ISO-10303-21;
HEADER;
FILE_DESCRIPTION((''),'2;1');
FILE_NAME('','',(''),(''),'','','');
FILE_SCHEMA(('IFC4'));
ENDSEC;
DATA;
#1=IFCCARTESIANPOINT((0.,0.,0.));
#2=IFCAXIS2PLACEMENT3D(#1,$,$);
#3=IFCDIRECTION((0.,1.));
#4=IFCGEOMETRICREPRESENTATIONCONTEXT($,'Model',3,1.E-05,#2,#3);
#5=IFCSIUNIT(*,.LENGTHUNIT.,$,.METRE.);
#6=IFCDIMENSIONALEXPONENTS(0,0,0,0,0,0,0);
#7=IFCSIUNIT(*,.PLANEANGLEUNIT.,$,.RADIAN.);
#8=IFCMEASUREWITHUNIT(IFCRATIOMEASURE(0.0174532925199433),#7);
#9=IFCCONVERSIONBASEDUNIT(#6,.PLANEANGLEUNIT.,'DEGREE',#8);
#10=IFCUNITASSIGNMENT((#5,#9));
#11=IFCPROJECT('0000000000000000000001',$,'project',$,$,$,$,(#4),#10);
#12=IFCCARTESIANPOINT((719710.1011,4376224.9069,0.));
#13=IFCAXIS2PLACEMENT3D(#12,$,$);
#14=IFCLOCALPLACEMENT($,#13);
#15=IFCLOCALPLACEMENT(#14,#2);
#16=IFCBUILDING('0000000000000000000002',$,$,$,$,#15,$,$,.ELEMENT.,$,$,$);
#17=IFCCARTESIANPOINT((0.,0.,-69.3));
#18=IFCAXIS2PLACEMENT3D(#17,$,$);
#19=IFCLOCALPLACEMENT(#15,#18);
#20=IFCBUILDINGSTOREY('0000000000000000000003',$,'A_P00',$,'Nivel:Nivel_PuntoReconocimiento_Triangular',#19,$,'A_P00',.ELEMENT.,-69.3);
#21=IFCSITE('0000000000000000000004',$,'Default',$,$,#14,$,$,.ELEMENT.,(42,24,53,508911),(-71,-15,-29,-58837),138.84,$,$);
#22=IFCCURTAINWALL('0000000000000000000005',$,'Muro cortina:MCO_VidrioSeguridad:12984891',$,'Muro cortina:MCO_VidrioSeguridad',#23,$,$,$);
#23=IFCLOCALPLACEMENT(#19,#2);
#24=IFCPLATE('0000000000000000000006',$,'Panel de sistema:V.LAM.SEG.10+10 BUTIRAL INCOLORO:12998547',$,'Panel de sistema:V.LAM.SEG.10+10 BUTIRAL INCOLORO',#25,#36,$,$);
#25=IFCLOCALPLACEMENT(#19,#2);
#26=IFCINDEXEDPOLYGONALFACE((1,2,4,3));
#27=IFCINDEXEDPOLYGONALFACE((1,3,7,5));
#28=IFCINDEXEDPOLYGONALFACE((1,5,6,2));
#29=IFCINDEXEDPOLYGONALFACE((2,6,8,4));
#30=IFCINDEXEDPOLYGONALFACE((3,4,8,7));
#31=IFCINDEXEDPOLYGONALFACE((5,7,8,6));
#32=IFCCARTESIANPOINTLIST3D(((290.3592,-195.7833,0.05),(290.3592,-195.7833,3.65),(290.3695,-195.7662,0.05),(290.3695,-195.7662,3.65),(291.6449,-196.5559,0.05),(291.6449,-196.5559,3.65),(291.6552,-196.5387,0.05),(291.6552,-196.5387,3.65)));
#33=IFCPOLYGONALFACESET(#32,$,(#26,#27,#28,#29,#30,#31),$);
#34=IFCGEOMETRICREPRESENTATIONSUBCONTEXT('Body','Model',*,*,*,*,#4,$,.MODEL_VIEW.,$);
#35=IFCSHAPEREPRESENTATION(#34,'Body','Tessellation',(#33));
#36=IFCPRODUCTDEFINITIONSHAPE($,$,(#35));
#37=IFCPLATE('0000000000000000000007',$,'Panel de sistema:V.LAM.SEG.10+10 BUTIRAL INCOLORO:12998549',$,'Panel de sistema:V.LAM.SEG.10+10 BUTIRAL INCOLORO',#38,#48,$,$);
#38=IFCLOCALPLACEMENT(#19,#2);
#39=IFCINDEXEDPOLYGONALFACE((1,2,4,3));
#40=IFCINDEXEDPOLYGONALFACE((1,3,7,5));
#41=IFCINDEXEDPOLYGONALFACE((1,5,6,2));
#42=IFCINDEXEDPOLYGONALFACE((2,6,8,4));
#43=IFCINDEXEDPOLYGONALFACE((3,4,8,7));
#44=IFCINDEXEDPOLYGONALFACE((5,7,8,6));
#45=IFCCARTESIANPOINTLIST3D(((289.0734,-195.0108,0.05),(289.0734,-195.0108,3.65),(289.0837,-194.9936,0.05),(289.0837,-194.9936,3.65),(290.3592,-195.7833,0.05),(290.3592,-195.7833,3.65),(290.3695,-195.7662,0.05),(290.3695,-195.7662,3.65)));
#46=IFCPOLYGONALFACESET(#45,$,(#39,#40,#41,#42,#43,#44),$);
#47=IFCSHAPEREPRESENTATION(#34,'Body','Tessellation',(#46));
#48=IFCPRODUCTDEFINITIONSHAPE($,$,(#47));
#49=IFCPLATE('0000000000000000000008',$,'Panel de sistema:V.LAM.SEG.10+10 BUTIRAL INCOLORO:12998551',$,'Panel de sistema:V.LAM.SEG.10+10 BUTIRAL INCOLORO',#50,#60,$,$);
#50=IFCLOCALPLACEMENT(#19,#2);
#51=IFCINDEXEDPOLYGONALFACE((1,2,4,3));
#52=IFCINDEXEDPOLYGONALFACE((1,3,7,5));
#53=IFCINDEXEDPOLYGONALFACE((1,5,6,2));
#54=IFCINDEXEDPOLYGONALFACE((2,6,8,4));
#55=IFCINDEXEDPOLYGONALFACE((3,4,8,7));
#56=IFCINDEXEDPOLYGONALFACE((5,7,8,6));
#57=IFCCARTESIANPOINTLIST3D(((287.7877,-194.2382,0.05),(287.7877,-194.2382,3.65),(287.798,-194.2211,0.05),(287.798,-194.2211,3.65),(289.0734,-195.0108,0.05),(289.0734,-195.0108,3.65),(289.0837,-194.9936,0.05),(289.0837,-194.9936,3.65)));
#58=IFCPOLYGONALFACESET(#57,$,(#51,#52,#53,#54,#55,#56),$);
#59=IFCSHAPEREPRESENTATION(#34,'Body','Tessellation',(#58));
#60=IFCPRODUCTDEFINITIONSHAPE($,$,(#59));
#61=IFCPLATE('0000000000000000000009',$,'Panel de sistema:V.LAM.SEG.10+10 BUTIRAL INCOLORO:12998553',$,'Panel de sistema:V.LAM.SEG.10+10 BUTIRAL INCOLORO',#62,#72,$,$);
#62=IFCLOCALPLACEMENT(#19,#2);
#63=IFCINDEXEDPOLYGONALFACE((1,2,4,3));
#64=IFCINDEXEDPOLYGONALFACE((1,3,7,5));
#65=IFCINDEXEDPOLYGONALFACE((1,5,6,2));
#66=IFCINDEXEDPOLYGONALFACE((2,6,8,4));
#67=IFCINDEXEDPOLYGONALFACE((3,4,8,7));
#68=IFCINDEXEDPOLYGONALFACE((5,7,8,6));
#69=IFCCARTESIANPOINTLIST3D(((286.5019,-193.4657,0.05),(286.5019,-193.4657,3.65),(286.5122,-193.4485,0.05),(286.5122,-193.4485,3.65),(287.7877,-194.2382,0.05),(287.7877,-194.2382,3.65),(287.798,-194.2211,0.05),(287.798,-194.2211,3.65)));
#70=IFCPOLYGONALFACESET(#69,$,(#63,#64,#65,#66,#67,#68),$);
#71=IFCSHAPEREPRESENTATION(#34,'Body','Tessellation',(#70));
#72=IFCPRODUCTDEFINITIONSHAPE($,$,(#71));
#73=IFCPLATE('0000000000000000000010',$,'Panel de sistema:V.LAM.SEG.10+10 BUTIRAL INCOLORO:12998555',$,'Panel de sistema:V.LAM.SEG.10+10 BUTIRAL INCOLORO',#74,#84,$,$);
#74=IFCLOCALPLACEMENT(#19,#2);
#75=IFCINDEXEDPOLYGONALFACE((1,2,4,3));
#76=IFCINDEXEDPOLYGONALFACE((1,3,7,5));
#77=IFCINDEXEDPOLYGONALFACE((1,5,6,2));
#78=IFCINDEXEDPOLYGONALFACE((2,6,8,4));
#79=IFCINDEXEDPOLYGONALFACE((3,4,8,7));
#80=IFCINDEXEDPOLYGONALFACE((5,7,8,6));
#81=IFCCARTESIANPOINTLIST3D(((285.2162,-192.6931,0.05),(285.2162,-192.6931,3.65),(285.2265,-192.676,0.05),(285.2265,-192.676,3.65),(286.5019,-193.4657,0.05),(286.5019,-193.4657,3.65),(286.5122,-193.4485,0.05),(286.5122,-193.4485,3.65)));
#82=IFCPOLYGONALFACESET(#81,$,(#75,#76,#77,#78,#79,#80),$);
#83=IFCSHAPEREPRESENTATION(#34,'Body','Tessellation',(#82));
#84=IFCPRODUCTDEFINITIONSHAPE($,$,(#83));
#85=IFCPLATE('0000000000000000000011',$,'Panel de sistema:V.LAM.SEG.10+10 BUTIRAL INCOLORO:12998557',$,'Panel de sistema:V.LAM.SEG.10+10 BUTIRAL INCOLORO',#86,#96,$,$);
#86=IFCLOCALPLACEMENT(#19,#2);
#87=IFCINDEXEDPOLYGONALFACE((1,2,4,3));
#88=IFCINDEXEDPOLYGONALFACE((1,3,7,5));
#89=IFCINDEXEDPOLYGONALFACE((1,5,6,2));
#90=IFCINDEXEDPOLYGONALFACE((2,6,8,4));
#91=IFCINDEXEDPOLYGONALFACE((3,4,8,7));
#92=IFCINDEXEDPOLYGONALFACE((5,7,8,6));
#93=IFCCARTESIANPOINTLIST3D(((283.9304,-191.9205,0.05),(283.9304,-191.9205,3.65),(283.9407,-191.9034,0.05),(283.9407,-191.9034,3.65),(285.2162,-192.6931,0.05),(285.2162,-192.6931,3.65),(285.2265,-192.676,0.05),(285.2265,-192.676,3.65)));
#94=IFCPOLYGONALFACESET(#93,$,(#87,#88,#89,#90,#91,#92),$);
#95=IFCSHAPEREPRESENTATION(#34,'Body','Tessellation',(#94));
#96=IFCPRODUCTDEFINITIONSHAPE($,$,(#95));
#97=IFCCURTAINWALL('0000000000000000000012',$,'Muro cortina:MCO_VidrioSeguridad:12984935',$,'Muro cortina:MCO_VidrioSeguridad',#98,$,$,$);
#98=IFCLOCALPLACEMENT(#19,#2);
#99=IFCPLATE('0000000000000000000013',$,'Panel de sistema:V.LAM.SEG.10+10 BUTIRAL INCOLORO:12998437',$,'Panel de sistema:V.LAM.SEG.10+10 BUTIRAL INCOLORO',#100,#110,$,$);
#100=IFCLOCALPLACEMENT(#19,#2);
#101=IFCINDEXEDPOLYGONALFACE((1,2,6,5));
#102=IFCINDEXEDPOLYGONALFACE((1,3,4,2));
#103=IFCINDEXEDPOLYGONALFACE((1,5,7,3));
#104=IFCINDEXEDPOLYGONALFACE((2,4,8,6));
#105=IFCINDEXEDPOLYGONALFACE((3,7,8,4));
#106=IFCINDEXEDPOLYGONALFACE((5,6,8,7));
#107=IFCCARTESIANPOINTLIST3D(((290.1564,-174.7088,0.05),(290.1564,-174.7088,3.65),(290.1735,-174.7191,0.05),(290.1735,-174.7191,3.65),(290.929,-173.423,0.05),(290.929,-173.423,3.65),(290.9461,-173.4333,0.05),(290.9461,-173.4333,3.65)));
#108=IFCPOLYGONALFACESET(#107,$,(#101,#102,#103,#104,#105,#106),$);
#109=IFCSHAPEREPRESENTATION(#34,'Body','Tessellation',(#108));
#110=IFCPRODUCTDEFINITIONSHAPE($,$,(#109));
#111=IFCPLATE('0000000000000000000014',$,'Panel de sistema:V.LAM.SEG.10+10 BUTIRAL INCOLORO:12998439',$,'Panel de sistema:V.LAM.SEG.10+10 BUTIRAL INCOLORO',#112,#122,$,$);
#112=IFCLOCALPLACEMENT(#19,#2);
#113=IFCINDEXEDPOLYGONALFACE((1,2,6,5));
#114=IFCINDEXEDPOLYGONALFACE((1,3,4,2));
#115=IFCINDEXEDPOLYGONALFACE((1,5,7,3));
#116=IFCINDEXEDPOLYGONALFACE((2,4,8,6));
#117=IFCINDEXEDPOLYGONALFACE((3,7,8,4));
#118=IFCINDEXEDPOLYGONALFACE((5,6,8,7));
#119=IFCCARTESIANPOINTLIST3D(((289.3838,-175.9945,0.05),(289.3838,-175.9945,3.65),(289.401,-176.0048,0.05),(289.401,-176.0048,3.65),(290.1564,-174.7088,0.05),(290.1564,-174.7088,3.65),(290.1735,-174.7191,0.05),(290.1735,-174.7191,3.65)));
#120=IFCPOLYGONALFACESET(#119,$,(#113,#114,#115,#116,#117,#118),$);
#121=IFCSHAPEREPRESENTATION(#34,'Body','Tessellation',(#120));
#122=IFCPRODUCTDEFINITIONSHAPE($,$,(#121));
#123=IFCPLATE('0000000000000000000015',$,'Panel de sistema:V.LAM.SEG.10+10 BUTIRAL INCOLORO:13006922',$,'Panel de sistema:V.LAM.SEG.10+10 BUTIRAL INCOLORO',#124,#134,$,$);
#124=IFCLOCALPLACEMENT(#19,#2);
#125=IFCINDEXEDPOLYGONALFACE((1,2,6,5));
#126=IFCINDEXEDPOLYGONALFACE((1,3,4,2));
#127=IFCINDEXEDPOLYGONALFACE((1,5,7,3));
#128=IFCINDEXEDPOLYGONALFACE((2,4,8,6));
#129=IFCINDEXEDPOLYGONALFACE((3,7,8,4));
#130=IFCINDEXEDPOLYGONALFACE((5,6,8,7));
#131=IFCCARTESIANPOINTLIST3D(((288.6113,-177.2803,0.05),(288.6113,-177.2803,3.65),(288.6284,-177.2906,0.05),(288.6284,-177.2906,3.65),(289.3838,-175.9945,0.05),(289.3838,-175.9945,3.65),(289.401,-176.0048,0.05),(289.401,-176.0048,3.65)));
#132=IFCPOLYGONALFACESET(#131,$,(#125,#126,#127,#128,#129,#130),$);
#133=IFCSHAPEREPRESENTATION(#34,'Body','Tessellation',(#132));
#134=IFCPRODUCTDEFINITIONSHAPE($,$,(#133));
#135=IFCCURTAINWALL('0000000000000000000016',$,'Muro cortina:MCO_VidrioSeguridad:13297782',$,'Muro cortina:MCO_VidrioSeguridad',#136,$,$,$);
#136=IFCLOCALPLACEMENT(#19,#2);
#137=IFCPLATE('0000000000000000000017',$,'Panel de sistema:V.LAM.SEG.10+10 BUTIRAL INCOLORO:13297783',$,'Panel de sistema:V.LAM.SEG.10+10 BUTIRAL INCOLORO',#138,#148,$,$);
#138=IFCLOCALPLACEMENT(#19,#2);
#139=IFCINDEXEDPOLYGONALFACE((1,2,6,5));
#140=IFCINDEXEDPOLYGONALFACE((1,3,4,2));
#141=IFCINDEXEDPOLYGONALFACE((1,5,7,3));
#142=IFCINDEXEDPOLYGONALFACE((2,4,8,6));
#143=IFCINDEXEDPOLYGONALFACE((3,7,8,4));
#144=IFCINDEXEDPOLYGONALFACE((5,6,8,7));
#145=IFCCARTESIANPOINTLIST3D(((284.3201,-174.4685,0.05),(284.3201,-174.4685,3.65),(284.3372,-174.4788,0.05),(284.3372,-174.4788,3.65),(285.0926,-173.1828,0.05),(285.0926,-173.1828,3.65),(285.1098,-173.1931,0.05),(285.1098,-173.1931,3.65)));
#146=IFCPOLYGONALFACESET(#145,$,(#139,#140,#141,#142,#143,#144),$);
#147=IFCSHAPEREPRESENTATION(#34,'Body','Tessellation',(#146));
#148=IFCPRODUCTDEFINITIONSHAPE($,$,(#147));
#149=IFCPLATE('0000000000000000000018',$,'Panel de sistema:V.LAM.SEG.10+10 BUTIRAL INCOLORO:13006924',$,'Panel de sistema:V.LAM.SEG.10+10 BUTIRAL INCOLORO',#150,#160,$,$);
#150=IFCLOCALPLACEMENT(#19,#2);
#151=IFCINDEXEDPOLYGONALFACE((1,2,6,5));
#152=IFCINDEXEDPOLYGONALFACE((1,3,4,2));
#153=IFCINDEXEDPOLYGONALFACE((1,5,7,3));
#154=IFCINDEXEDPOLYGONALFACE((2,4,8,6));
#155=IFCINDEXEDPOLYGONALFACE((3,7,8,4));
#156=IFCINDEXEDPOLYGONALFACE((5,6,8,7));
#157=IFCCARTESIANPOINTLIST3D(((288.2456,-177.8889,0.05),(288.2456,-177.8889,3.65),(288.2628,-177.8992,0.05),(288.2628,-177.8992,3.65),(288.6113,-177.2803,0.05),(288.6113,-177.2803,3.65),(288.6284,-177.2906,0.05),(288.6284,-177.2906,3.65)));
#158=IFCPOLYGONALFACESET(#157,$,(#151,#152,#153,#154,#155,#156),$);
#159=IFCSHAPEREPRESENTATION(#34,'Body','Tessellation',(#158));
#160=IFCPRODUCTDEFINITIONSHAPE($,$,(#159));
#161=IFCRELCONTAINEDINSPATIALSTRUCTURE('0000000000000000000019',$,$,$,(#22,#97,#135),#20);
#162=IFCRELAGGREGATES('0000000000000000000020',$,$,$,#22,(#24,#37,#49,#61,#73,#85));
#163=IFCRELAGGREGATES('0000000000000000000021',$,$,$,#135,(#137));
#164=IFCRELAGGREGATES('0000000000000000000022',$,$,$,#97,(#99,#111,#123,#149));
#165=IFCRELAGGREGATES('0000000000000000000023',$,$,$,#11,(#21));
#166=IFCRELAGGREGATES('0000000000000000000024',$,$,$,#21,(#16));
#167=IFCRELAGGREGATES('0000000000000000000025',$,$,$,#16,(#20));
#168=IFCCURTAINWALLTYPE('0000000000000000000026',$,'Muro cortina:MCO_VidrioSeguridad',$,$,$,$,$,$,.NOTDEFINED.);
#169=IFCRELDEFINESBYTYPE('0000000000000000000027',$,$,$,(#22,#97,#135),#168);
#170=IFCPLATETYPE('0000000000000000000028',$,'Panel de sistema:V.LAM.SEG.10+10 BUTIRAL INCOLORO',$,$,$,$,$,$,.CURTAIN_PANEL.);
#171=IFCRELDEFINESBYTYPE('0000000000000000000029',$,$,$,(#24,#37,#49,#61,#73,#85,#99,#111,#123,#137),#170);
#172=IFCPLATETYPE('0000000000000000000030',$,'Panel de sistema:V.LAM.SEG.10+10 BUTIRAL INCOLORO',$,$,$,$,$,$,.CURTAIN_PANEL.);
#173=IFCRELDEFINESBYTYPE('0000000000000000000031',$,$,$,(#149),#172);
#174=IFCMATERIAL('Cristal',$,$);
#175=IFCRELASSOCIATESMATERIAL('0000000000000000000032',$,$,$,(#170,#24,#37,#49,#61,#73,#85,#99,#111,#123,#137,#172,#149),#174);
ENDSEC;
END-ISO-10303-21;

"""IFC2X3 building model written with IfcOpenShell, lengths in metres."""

from ifc_helpers import new_model, entity, si_unit, converted_unit, direction, frame, origin, origin_2d_with_axis, place, context, subcontext, project, spatial, rectangle, extrude, source, transform, mapped, material, type_object, type_shapes, element, aggregate, save


model = new_model("IFC2X3")

# Units and contexts
model_context = context("Model", 3, precision=1e-05, world=origin(), true_north=direction((0.0, 1.0)))
body_context = subcontext(model_context, "Body", "Model", "MODEL_VIEW")
ifc_project = project(units=[si_unit("LENGTHUNIT", "METRE"), converted_unit("PLANEANGLEUNIT", "DEGREE", entity("IfcRatioMeasure", 0.0174532925199433), si_unit("PLANEANGLEUNIT", "RADIAN"), dimensions=[0, 0, 0, 0, 0, 0, 0])], contexts=[model_context])

# Site, building, storey
site_placement = place(None, frame((719710.1011, 4376224.9069, 0.0)))
site = spatial("IfcSite", under=ifc_project, at=site_placement, Name="Default", CompositionType="ELEMENT", RefLatitude=(42, 24, 53, 508911), RefLongitude=(-71, -15, -29, -58837), RefElevation=138.84)
building_placement = place(site_placement, origin())
building = spatial("IfcBuilding", under=site, at=building_placement, CompositionType="ELEMENT")
storey_placement = place(building_placement, frame((0.0, 0.0, -69.3)))
storey = spatial("IfcBuildingStorey", under=building, at=storey_placement, Name="A_P00", ObjectType="Nivel:Nivel_PuntoReconocimiento_Triangular", LongName="A_P00", CompositionType="ELEMENT", Elevation=-69.3)

# Curtain walls, plates
curtain_wall_type = type_object("IfcCurtainWallType", Name="Muro cortina:MCO_VidrioSeguridad", PredefinedType="NOTDEFINED")
curtain_wall_1_placement = place(storey_placement, frame((0.0, 0.0, 69.3)))
curtain_wall_1 = element("IfcCurtainWall", 1, at=curtain_wall_1_placement, inside=storey, type_object=curtain_wall_type, Name="Muro cortina:MCO_VidrioSeguridad:12984891", ObjectType="Muro cortina:MCO_VidrioSeguridad")
ifc_material_1 = material(Name="Cristal")
plate_type_1 = type_object("IfcPlateType", Name="Panel de sistema:V.LAM.SEG.10+10 BUTIRAL INCOLORO", PredefinedType="CURTAIN_PANEL", material=ifc_material_1)
shared_shape_1 = source(origin(), body_context, "Body", "SweptSolid", [
    extrude(rectangle(XDim=0.02, YDim=1.5, at=origin_2d_with_axis()), frame((0.0, 0.0, 0.0), z_axis=(0.0, 0.0, 1.0), x_axis=(0.0, 1.0, 0.0)), (0.0, 0.0, 1.0), 3.6),
])
type_shapes(plate_type_1, [shared_shape_1])
plate_1_placement = place(curtain_wall_1_placement, frame((291.0072, -196.161, -69.25), z_axis=(0.0, 0.0, 1.0), x_axis=(-0.857167, 0.515038, 0.0)))
plate_1 = element("IfcPlate", 2, at=plate_1_placement, type_object=plate_type_1, material=ifc_material_1, Name="Panel de sistema:V.LAM.SEG.10+10 BUTIRAL INCOLORO:12998547", ObjectType="Panel de sistema:V.LAM.SEG.10+10 BUTIRAL INCOLORO", context=body_context, shape_type="MappedRepresentation", body=[
    mapped(shared_shape_1, transform((0.0, 0.0, 0.0), scale=1.0)),
])
plate_2_placement = place(curtain_wall_1_placement, frame((289.7214, -195.3885, -69.25), z_axis=(0.0, 0.0, 1.0), x_axis=(-0.857167, 0.515038, 0.0)))
plate_2 = element("IfcPlate", 3, at=plate_2_placement, type_object=plate_type_1, material=ifc_material_1, Name="Panel de sistema:V.LAM.SEG.10+10 BUTIRAL INCOLORO:12998549", ObjectType="Panel de sistema:V.LAM.SEG.10+10 BUTIRAL INCOLORO", context=body_context, shape_type="MappedRepresentation", body=[
    mapped(shared_shape_1, transform((0.0, 0.0, 0.0), scale=1.0)),
])
plate_3_placement = place(curtain_wall_1_placement, frame((288.4357, -194.6159, -69.25), z_axis=(0.0, 0.0, 1.0), x_axis=(-0.857167, 0.515038, 0.0)))
plate_3 = element("IfcPlate", 4, at=plate_3_placement, type_object=plate_type_1, material=ifc_material_1, Name="Panel de sistema:V.LAM.SEG.10+10 BUTIRAL INCOLORO:12998551", ObjectType="Panel de sistema:V.LAM.SEG.10+10 BUTIRAL INCOLORO", context=body_context, shape_type="MappedRepresentation", body=[
    mapped(shared_shape_1, transform((0.0, 0.0, 0.0), scale=1.0)),
])
plate_4_placement = place(curtain_wall_1_placement, frame((287.1499, -193.8434, -69.25), z_axis=(0.0, 0.0, 1.0), x_axis=(-0.857167, 0.515038, 0.0)))
plate_4 = element("IfcPlate", 5, at=plate_4_placement, type_object=plate_type_1, material=ifc_material_1, Name="Panel de sistema:V.LAM.SEG.10+10 BUTIRAL INCOLORO:12998553", ObjectType="Panel de sistema:V.LAM.SEG.10+10 BUTIRAL INCOLORO", context=body_context, shape_type="MappedRepresentation", body=[
    mapped(shared_shape_1, transform((0.0, 0.0, 0.0), scale=1.0)),
])
plate_5_placement = place(curtain_wall_1_placement, frame((285.8642, -193.0708, -69.25), z_axis=(0.0, 0.0, 1.0), x_axis=(-0.857167, 0.515038, 0.0)))
plate_5 = element("IfcPlate", 6, at=plate_5_placement, type_object=plate_type_1, material=ifc_material_1, Name="Panel de sistema:V.LAM.SEG.10+10 BUTIRAL INCOLORO:12998555", ObjectType="Panel de sistema:V.LAM.SEG.10+10 BUTIRAL INCOLORO", context=body_context, shape_type="MappedRepresentation", body=[
    mapped(shared_shape_1, transform((0.0, 0.0, 0.0), scale=1.0)),
])
plate_6_placement = place(curtain_wall_1_placement, frame((284.5784, -192.2983, -69.25), z_axis=(0.0, 0.0, 1.0), x_axis=(-0.857167, 0.515038, 0.0)))
plate_6 = element("IfcPlate", 7, at=plate_6_placement, type_object=plate_type_1, material=ifc_material_1, Name="Panel de sistema:V.LAM.SEG.10+10 BUTIRAL INCOLORO:12998557", ObjectType="Panel de sistema:V.LAM.SEG.10+10 BUTIRAL INCOLORO", context=body_context, shape_type="MappedRepresentation", body=[
    mapped(shared_shape_1, transform((0.0, 0.0, 0.0), scale=1.0)),
])
aggregate(curtain_wall_1, [plate_1, plate_2, plate_3, plate_4, plate_5, plate_6])
curtain_wall_2_placement = place(storey_placement, frame((0.0, 0.0, 69.3)))
curtain_wall_2 = element("IfcCurtainWall", 8, at=curtain_wall_2_placement, inside=storey, type_object=curtain_wall_type, Name="Muro cortina:MCO_VidrioSeguridad:12984935", ObjectType="Muro cortina:MCO_VidrioSeguridad")
plate_7_placement = place(curtain_wall_2_placement, frame((290.5513, -174.071, -69.25), z_axis=(0.0, 0.0, 1.0), x_axis=(-0.515038, -0.857167, 0.0)))
plate_7 = element("IfcPlate", 9, at=plate_7_placement, type_object=plate_type_1, material=ifc_material_1, Name="Panel de sistema:V.LAM.SEG.10+10 BUTIRAL INCOLORO:12998437", ObjectType="Panel de sistema:V.LAM.SEG.10+10 BUTIRAL INCOLORO", context=body_context, shape_type="MappedRepresentation", body=[
    mapped(shared_shape_1, transform((0.0, 0.0, 0.0), scale=1.0)),
])
plate_8_placement = place(curtain_wall_2_placement, frame((289.7787, -175.3568, -69.25), z_axis=(0.0, 0.0, 1.0), x_axis=(-0.515038, -0.857167, 0.0)))
plate_8 = element("IfcPlate", 10, at=plate_8_placement, type_object=plate_type_1, material=ifc_material_1, Name="Panel de sistema:V.LAM.SEG.10+10 BUTIRAL INCOLORO:12998439", ObjectType="Panel de sistema:V.LAM.SEG.10+10 BUTIRAL INCOLORO", context=body_context, shape_type="MappedRepresentation", body=[
    mapped(shared_shape_1, transform((0.0, 0.0, 0.0), scale=1.0)),
])
plate_9_placement = place(curtain_wall_2_placement, frame((289.0061, -176.6425, -69.25), z_axis=(0.0, 0.0, 1.0), x_axis=(-0.515038, -0.857167, 0.0)))
plate_9 = element("IfcPlate", 11, at=plate_9_placement, type_object=plate_type_1, material=ifc_material_1, Name="Panel de sistema:V.LAM.SEG.10+10 BUTIRAL INCOLORO:13006922", ObjectType="Panel de sistema:V.LAM.SEG.10+10 BUTIRAL INCOLORO", context=body_context, shape_type="MappedRepresentation", body=[
    mapped(shared_shape_1, transform((0.0, 0.0, 0.0), scale=1.0)),
])

# Curtain wall, plate
curtain_wall_3_placement = place(storey_placement, frame((0.0, 0.0, 69.3)))
curtain_wall_3 = element("IfcCurtainWall", 12, at=curtain_wall_3_placement, inside=storey, type_object=curtain_wall_type, Name="Muro cortina:MCO_VidrioSeguridad:13297782", ObjectType="Muro cortina:MCO_VidrioSeguridad")
plate_10_placement = place(curtain_wall_3_placement, frame((284.7149, -173.8308, -69.25), z_axis=(0.0, 0.0, 1.0), x_axis=(0.515038, 0.857167, 0.0)))
plate_10 = element("IfcPlate", 13, at=plate_10_placement, type_object=plate_type_1, material=ifc_material_1, Name="Panel de sistema:V.LAM.SEG.10+10 BUTIRAL INCOLORO:13297783", ObjectType="Panel de sistema:V.LAM.SEG.10+10 BUTIRAL INCOLORO", context=body_context, shape_type="MappedRepresentation", body=[
    mapped(shared_shape_1, transform((0.0, 0.0, 0.0), scale=1.0)),
])
aggregate(curtain_wall_3, [plate_10])

# Plate
plate_type_2 = type_object("IfcPlateType", Name="Panel de sistema:V.LAM.SEG.10+10 BUTIRAL INCOLORO", PredefinedType="CURTAIN_PANEL", material=ifc_material_1)
shared_shape_2 = source(origin(), body_context, "Body", "SweptSolid", [
    extrude(rectangle(XDim=0.02, YDim=0.71, at=origin_2d_with_axis()), frame((0.0, 0.0, 0.0), z_axis=(0.0, 0.0, 1.0), x_axis=(0.0, 1.0, 0.0)), (0.0, 0.0, 1.0), 3.6),
])
type_shapes(plate_type_2, [shared_shape_2])
plate_11_placement = place(curtain_wall_2_placement, frame((288.437, -177.5897, -69.25), z_axis=(0.0, 0.0, 1.0), x_axis=(-0.515038, -0.857167, 0.0)))
plate_11 = element("IfcPlate", 14, at=plate_11_placement, type_object=plate_type_2, material=ifc_material_1, Name="Panel de sistema:V.LAM.SEG.10+10 BUTIRAL INCOLORO:13006924", ObjectType="Panel de sistema:V.LAM.SEG.10+10 BUTIRAL INCOLORO", context=body_context, shape_type="MappedRepresentation", body=[
    mapped(shared_shape_2, transform((0.0, 0.0, 0.0), scale=1.0)),
])
aggregate(curtain_wall_2, [plate_7, plate_8, plate_9, plate_11])

save(model, "model.ifc")
